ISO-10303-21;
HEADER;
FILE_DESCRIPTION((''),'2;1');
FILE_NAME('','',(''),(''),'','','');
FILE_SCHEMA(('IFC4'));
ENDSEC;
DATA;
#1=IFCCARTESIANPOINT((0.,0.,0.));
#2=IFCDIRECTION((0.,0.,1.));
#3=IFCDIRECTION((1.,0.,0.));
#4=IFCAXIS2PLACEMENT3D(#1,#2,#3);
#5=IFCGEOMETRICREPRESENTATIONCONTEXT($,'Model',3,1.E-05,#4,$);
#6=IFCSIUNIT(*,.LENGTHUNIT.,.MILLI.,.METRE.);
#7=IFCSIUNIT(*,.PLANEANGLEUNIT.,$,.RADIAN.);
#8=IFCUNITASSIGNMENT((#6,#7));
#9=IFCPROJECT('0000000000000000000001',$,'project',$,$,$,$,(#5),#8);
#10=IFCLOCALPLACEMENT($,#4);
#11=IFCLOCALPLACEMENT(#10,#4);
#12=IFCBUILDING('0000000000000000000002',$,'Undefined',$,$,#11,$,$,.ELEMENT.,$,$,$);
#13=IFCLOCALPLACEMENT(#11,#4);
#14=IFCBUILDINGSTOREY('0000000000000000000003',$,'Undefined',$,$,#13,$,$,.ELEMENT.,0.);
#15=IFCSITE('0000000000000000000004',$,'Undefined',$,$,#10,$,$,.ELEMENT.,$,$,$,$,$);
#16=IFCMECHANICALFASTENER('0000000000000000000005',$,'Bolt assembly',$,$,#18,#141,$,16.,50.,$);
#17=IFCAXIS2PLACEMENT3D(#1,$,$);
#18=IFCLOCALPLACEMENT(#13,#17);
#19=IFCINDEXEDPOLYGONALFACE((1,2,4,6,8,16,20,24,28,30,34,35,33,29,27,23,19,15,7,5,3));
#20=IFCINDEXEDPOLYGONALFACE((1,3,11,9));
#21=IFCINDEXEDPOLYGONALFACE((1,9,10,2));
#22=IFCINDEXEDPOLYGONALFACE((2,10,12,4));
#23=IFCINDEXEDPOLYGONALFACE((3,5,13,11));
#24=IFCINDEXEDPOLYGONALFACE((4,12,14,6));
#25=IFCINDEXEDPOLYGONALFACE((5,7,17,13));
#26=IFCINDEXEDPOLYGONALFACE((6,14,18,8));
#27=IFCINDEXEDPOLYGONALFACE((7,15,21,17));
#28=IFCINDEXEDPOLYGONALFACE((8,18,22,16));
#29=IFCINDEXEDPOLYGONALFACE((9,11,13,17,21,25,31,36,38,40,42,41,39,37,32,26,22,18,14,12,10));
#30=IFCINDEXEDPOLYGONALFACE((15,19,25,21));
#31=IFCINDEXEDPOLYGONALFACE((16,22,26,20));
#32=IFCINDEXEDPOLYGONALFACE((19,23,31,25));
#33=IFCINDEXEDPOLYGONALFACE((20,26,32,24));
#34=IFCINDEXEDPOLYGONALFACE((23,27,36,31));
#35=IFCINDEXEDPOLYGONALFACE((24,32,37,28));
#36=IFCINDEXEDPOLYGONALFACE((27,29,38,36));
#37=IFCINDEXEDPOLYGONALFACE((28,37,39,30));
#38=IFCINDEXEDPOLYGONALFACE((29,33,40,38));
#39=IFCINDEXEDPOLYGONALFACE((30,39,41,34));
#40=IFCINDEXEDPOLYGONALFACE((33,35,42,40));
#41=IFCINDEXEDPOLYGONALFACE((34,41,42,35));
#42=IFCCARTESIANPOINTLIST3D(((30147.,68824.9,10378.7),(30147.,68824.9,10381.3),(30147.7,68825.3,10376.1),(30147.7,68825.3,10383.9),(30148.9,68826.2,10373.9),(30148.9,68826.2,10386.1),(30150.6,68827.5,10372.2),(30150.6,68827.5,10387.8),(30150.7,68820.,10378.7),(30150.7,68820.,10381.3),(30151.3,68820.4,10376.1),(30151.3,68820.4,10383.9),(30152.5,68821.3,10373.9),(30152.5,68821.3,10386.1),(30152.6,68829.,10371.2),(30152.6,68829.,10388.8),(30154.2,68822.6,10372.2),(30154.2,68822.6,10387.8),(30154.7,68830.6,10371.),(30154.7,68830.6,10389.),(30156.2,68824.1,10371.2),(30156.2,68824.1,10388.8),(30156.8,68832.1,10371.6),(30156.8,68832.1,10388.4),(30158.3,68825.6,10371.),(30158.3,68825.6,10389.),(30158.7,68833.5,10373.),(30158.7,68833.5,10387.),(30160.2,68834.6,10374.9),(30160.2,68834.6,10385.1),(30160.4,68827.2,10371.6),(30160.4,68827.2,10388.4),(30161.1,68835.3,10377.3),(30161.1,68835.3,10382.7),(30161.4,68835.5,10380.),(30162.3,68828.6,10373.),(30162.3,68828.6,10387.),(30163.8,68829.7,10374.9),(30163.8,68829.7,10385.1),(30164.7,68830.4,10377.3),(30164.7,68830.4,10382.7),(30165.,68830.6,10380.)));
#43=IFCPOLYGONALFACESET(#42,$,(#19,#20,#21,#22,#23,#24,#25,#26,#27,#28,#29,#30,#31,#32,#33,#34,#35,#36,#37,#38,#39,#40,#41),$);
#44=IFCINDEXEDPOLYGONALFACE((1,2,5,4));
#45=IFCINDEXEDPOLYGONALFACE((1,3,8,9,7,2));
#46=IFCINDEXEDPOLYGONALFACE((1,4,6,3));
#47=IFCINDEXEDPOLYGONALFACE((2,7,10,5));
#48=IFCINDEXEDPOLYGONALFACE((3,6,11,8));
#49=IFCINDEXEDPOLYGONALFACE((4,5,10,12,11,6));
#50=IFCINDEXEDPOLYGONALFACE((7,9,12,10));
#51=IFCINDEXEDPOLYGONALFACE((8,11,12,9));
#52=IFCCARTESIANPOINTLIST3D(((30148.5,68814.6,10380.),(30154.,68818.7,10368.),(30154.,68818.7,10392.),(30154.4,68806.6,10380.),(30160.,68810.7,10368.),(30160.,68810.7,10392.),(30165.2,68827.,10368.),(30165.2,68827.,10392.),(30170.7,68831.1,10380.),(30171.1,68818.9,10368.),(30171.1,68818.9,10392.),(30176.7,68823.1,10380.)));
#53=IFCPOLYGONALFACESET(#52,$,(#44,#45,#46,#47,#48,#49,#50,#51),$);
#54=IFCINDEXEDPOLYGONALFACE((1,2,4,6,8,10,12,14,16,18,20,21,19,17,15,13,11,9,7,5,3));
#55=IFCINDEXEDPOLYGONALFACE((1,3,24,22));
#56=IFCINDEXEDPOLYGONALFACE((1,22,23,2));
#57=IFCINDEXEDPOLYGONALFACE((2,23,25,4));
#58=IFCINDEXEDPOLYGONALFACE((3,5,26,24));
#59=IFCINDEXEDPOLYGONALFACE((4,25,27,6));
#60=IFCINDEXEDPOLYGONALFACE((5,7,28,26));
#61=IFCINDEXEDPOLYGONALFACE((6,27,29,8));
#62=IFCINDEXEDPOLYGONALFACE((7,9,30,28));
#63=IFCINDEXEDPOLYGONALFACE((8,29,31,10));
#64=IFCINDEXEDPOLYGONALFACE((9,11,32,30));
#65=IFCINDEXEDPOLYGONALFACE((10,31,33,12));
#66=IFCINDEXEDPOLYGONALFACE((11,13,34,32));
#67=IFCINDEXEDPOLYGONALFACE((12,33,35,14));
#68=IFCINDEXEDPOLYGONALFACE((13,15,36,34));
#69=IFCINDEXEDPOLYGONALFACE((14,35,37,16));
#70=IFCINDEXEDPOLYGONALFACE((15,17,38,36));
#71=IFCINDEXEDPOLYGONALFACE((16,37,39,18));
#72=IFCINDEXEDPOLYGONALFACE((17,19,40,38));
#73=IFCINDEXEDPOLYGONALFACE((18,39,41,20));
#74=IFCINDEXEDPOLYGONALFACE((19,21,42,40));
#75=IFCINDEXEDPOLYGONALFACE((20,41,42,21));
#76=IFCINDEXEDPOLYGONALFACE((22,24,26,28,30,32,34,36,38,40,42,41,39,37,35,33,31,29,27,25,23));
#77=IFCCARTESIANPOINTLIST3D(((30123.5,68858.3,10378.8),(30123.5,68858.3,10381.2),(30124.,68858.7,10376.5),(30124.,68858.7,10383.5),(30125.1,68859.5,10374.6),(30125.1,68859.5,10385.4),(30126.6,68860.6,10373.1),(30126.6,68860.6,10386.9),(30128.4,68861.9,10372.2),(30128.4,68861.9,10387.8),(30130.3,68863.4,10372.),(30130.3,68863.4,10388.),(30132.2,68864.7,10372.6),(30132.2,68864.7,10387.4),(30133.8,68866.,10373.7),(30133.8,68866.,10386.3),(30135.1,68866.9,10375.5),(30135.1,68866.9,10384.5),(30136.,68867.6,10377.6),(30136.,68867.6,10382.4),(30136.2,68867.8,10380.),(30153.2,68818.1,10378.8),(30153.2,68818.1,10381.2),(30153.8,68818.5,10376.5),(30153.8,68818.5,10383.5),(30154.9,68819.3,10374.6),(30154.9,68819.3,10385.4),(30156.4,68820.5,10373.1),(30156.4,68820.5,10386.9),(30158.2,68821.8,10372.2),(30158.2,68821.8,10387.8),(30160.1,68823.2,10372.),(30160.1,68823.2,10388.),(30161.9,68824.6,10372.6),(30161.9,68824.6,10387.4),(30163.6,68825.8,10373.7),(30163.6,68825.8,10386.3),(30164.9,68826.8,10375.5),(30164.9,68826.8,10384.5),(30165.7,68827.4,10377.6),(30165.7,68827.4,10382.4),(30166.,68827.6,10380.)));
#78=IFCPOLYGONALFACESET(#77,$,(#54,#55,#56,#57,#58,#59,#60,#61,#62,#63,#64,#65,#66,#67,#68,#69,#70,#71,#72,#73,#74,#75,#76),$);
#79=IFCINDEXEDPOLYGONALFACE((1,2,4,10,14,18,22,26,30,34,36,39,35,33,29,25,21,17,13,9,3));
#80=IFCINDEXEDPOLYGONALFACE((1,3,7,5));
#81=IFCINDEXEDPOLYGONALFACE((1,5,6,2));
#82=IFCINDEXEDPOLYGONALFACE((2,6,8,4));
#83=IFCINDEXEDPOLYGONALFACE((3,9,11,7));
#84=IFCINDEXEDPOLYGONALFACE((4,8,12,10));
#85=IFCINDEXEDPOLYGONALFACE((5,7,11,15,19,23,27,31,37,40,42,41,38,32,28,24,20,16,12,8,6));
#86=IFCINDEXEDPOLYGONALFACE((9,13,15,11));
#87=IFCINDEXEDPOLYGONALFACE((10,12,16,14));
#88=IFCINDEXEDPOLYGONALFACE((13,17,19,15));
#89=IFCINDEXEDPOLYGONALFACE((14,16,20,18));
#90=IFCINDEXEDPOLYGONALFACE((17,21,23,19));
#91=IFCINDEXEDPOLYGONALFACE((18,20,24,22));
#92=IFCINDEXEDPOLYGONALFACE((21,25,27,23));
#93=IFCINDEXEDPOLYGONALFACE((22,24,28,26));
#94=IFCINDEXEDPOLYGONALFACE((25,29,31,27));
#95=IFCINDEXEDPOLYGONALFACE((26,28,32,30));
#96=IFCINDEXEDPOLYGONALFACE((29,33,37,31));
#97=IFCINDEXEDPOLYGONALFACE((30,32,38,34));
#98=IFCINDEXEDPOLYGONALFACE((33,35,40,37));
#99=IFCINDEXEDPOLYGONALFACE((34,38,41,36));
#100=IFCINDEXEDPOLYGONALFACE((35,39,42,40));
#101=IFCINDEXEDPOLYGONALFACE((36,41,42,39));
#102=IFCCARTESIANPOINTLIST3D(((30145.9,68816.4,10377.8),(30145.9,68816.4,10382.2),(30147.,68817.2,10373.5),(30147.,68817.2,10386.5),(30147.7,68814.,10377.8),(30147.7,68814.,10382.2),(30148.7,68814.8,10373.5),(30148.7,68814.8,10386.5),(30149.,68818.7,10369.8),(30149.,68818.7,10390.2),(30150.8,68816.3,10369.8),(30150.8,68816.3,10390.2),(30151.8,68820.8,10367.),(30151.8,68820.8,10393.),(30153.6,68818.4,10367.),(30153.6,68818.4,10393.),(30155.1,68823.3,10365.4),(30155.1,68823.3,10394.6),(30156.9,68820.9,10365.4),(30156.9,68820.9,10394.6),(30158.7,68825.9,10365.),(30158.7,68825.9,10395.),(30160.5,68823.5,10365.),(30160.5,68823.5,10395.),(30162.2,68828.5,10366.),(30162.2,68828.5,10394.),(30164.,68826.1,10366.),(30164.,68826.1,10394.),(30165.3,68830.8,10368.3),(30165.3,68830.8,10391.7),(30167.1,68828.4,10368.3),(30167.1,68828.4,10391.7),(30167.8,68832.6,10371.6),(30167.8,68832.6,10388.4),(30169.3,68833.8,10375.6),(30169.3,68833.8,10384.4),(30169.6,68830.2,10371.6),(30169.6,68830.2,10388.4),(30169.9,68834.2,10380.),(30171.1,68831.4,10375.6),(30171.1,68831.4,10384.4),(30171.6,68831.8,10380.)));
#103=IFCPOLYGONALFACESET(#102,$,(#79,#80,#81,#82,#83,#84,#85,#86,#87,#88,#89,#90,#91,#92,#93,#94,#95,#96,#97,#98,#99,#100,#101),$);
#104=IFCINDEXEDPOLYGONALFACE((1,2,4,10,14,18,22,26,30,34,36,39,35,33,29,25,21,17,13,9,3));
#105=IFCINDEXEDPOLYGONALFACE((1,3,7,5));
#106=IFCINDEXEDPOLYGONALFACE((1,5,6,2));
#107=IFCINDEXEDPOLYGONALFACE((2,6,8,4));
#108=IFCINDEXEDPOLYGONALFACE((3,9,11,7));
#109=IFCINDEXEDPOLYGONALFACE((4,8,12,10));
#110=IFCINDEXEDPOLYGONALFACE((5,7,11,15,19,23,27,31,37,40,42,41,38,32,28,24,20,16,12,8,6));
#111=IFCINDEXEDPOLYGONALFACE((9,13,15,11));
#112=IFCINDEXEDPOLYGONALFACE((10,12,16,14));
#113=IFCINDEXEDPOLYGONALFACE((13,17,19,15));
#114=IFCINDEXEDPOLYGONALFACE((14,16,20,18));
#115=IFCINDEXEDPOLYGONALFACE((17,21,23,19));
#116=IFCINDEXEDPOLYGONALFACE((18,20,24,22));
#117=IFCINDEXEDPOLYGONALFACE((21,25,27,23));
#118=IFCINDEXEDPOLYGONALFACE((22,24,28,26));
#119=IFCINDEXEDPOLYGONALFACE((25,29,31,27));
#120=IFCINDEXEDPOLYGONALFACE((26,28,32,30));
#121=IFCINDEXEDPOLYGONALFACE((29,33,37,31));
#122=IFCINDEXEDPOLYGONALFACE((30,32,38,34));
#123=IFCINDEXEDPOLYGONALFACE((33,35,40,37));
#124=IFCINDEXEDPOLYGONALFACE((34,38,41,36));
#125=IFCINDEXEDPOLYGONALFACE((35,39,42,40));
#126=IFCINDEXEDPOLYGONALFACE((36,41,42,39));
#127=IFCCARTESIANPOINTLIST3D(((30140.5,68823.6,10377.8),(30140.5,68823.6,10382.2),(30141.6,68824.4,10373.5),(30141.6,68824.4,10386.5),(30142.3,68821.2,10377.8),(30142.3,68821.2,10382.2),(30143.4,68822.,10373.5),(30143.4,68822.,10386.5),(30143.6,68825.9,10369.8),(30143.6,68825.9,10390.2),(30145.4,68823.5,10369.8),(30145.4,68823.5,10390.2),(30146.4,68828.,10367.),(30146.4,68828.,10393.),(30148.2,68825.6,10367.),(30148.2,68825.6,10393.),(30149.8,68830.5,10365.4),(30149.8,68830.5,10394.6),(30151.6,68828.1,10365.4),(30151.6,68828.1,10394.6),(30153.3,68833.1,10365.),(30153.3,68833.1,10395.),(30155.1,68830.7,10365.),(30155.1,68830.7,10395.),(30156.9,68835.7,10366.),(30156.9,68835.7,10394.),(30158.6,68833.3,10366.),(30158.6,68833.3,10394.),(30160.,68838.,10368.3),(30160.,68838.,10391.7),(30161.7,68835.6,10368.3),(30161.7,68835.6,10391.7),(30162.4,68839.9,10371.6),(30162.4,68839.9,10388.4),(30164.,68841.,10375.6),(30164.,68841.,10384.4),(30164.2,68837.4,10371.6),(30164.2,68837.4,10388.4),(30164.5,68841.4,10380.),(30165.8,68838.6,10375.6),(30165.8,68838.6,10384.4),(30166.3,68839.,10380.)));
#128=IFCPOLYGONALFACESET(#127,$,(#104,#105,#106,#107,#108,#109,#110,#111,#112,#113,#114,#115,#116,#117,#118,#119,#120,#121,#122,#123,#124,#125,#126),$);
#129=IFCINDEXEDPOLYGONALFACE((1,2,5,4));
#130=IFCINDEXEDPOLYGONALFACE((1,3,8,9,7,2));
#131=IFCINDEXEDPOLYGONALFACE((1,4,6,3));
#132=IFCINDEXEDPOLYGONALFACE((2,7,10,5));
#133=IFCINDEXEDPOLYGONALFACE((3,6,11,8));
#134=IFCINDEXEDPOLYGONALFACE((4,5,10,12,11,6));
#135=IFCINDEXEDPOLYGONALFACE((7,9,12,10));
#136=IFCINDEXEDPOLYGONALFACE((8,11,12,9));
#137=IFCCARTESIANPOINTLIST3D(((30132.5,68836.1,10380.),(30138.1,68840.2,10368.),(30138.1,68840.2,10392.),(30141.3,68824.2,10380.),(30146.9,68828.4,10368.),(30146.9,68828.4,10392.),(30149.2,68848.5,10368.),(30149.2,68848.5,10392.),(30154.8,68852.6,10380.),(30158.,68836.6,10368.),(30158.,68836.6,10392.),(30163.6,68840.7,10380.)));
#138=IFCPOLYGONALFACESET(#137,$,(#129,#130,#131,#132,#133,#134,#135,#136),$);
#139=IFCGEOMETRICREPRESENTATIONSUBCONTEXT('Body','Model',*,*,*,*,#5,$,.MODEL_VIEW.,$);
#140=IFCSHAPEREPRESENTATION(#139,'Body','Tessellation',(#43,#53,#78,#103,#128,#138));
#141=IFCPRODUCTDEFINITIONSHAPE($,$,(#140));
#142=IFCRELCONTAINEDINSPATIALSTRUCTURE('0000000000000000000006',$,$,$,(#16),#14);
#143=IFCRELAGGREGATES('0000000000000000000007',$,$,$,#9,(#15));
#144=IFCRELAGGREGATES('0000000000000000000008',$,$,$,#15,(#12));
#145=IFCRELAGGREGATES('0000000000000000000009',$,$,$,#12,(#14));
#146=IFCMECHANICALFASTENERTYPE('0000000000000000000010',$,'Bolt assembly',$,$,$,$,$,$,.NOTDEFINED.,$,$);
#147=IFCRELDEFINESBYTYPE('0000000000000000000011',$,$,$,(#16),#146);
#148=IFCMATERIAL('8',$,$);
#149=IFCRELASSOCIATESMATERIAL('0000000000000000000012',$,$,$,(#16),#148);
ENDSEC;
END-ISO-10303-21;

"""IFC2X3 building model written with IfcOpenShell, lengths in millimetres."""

from ifc_helpers import new_model, si_unit, frame, origin_with_axes, origin_2d_with_axis, place, context, subcontext, project, spatial, polyline, circle, outline, extrude, source, transform, mapped, material, type_object, element, save


model = new_model("IFC2X3")

# Units and contexts
model_context = context("Model", 3, precision=1e-05, world=origin_with_axes())
body_context = subcontext(model_context, "Body", "Model", "MODEL_VIEW")
ifc_project = project(units=[si_unit("LENGTHUNIT", "METRE", prefix="MILLI"), si_unit("PLANEANGLEUNIT", "RADIAN")], contexts=[model_context])

# Site, building, storey
site_placement = place(None, origin_with_axes())
site = spatial("IfcSite", under=ifc_project, at=site_placement, Name="Undefined", CompositionType="ELEMENT")
building_placement = place(site_placement, origin_with_axes())
building = spatial("IfcBuilding", under=site, at=building_placement, Name="Undefined", CompositionType="ELEMENT")
storey_placement = place(building_placement, origin_with_axes())
storey = spatial("IfcBuildingStorey", under=building, at=storey_placement, Name="Undefined", CompositionType="ELEMENT", Elevation=0.0)

# Mechanical fastener
ifc_material_1 = material(Name="8")
mechanical_fastener_type = type_object("IfcMechanicalFastenerType", Name="Bolt assembly")
shared_shape_1 = source(origin_with_axes(), body_context, "Body", "SweptSolid", [
    extrude(circle(Radius=9.0, at=origin_2d_with_axis()), frame((0.0, 8.0, 0.0), z_axis=(0.0, 1.0, 0.0), x_axis=(1.0, 0.0, 0.0)), (0.0, 0.0, 1.0), 6.1),
    extrude(outline(polyline([(13.9, 0.0), (6.9, 12.0), (-6.9, 12.0), (-13.9, 0.0), (-6.9, -12.0), (6.9, -12.0), (13.9, 0.0)])), frame((0.0, -5.0, 0.0), z_axis=(0.0, 1.0, 0.0), x_axis=(1.0, 0.0, 0.0)), (0.0, 0.0, 1.0), 10.0),
    extrude(circle(Radius=8.0, at=origin_2d_with_axis()), frame((0.0, 5.0, 0.0), z_axis=(0.0, 1.0, 0.0), x_axis=(1.0, 0.0, 0.0)), (0.0, 0.0, 1.0), 50.0),
    extrude(circle(Radius=15.0, at=origin_2d_with_axis()), frame((0.0, 5.0, 0.0), z_axis=(0.0, 1.0, 0.0), x_axis=(1.0, 0.0, 0.0)), (0.0, 0.0, 1.0), 3.0),
    extrude(circle(Radius=15.0, at=origin_2d_with_axis()), frame((0.0, 14.0, 0.0), z_axis=(0.0, 1.0, 0.0), x_axis=(1.0, 0.0, 0.0)), (0.0, 0.0, 1.0), 3.0),
    extrude(outline(polyline([(13.9, 0.0), (6.9, 12.0), (-6.9, 12.0), (-13.9, 0.0), (-6.9, -12.0), (6.9, -12.0), (13.9, 0.0)])), frame((0.0, 17.0, 0.0), z_axis=(0.0, 1.0, 0.0), x_axis=(1.0, 0.0, 0.0)), (0.0, 0.0, 1.0), 14.8),
])
for number, where, z_axis, x_axis, name in (
    (1, (30162.6, 68818.8, 10380.0), (0.0, 0.0, 1.0), (0.803401, 0.595438, 0.0), "Bolt assembly"),
):
    element("IfcMechanicalFastener", number, at=place(storey_placement, frame(where, z_axis=z_axis, x_axis=x_axis)), inside=storey, type_object=mechanical_fastener_type, material=ifc_material_1, Name=name, NominalDiameter=16.0, NominalLength=50.0, context=body_context, shape_type="MappedRepresentation", body=[
        mapped(shared_shape_1, transform((0.0, 0.0, 0.0))),
    ])

save(model, "model.ifc")
